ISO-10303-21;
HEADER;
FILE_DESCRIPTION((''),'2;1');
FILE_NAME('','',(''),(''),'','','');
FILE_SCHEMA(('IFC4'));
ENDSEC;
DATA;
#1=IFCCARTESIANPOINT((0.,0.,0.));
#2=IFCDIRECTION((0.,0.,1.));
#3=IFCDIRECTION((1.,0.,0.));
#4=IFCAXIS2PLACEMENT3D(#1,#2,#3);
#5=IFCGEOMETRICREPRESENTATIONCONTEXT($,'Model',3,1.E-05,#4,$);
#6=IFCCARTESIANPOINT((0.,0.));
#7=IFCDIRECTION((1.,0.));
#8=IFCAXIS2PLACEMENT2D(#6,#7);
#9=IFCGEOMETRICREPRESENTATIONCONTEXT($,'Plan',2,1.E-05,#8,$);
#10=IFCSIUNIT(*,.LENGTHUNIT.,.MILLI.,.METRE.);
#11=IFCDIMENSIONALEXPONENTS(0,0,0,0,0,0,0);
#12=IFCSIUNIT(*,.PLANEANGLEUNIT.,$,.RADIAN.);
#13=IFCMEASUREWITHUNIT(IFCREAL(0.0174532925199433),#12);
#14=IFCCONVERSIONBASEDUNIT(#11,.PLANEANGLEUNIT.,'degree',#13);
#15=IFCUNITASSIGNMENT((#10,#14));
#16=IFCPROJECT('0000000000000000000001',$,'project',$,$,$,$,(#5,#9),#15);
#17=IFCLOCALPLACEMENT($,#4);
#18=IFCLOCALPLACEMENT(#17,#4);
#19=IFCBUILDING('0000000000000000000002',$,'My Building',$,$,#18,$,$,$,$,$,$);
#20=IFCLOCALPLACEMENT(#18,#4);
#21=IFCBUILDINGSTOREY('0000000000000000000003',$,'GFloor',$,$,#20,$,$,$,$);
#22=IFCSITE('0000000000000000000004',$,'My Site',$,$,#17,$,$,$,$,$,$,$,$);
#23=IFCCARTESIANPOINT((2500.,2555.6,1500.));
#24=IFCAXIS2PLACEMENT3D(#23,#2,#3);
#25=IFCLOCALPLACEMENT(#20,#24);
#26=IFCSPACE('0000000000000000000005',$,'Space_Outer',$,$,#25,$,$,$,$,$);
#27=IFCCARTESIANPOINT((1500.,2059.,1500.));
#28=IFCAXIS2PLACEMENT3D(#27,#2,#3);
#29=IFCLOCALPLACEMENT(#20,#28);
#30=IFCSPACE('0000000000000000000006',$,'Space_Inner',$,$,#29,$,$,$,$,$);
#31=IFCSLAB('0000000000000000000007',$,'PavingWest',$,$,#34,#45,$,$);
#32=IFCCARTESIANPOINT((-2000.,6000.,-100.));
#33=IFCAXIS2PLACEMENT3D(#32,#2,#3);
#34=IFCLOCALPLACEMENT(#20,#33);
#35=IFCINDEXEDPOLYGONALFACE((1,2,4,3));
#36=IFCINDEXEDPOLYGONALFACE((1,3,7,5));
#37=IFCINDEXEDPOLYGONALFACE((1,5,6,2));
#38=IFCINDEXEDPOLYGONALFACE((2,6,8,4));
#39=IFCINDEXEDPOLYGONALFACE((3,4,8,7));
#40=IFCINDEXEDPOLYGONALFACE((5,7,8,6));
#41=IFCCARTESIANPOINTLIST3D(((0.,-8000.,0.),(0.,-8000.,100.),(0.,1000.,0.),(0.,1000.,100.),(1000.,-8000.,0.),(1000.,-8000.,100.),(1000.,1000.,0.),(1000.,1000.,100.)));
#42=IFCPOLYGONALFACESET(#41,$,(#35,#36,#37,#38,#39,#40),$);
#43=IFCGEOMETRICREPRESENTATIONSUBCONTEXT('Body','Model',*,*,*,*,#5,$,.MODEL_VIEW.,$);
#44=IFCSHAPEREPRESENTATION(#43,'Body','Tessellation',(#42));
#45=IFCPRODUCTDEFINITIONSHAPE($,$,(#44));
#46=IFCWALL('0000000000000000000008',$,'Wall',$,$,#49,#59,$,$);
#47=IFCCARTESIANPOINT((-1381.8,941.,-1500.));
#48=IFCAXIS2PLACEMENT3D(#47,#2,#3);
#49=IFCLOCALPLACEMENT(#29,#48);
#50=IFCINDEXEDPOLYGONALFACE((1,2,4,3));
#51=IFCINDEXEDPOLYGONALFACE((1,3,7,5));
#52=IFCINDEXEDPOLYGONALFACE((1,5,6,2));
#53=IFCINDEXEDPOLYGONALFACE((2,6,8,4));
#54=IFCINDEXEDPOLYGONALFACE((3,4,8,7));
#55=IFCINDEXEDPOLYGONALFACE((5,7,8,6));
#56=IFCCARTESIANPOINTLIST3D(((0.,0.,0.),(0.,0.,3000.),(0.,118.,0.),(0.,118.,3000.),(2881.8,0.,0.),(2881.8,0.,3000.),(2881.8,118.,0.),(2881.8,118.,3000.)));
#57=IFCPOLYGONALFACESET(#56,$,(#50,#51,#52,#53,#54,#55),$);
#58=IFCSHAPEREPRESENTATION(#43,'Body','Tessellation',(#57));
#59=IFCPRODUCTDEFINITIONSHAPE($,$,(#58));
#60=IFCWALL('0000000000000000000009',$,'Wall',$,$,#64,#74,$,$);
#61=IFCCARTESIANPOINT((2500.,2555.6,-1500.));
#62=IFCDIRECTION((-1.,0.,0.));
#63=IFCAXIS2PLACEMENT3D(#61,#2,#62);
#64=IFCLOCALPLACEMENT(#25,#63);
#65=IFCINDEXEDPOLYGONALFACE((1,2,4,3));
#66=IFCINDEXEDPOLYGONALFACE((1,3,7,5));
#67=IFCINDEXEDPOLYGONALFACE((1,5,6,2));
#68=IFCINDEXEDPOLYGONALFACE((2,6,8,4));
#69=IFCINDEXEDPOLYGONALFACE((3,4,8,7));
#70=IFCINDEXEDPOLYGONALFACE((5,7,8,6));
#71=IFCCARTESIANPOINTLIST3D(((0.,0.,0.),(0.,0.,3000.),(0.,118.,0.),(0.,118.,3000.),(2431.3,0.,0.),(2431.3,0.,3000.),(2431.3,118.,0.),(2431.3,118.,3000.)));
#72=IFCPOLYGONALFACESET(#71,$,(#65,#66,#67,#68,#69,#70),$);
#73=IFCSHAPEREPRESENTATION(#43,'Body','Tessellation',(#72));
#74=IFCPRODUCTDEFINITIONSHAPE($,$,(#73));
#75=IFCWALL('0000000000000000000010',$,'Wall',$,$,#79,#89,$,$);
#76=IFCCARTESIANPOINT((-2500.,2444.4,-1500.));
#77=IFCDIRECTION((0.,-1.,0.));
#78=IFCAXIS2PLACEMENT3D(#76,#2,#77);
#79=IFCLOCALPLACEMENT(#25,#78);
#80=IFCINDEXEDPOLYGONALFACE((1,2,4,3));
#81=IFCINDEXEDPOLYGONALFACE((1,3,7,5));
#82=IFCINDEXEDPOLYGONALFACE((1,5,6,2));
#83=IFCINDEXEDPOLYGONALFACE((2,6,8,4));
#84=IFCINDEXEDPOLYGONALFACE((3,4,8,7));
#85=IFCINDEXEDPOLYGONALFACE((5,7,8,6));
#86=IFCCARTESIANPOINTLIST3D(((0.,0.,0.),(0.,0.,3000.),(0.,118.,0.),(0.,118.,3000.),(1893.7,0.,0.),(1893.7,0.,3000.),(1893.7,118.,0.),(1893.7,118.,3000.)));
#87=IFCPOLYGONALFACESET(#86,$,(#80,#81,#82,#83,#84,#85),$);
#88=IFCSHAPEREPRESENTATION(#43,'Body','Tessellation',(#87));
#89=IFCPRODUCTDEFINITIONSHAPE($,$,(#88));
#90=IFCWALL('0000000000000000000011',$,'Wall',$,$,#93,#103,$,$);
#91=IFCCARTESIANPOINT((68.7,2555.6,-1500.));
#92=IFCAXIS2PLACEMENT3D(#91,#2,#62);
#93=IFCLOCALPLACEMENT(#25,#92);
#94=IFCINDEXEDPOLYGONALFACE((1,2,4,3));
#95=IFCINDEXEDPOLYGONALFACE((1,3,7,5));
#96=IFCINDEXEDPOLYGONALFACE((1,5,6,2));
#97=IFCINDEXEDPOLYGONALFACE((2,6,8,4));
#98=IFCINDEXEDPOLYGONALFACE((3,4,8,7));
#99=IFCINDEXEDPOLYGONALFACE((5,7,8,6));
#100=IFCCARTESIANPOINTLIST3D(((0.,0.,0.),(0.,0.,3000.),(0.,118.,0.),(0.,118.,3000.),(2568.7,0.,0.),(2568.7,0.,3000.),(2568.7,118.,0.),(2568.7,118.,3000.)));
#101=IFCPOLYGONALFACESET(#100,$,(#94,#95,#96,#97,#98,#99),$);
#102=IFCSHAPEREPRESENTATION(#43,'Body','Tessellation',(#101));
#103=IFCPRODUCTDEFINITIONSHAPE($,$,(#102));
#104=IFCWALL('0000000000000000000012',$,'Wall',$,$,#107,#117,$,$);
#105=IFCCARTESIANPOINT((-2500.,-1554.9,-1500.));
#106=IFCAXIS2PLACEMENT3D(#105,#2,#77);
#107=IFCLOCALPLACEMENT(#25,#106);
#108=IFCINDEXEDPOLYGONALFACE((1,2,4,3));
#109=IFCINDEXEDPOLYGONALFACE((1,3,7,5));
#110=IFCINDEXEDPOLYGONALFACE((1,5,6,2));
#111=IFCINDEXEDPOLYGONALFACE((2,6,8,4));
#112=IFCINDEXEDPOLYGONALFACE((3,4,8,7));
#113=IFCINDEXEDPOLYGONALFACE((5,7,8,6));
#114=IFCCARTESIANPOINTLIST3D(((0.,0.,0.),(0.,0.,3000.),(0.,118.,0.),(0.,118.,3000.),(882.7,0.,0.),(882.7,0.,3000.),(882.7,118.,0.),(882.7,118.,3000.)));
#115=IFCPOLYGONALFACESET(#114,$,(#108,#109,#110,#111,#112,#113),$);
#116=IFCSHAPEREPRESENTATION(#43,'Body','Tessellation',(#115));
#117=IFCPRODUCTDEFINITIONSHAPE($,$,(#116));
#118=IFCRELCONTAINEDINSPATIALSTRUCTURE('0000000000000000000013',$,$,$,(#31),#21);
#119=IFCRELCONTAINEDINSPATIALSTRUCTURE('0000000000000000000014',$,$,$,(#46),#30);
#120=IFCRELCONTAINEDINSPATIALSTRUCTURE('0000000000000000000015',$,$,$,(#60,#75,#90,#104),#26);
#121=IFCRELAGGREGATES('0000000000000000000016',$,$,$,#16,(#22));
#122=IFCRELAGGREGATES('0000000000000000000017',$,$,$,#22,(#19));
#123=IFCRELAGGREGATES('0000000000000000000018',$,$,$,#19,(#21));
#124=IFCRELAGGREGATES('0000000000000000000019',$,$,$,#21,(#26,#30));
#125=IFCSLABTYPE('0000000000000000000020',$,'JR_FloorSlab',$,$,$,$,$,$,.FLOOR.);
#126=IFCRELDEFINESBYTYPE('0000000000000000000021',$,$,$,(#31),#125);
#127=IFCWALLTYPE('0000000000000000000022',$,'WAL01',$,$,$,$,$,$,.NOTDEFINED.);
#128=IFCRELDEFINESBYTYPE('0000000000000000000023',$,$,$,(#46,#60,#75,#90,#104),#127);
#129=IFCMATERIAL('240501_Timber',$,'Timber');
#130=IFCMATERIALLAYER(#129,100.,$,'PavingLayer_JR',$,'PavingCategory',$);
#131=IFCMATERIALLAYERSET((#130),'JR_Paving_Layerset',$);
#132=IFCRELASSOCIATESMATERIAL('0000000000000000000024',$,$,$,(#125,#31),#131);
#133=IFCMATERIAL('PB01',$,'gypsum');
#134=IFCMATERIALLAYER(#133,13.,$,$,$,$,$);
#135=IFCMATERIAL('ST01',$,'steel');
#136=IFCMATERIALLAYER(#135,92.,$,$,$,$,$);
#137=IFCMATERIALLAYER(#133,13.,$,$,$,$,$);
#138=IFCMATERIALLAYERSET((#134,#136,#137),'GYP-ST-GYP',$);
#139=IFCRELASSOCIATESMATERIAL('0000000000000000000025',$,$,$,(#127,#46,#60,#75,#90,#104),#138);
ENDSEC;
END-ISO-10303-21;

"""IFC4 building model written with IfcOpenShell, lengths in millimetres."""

from ifc_helpers import new_model, entity, si_unit, converted_unit, frame, origin_with_axes, origin_2d_with_axis, place, context, subcontext, project, spatial, line, indexed_curve, outline, extrude, material, layer, layer_set, layer_usage, type_object, element, save


model = new_model("IFC4")

# Units and contexts
model_context = context("Model", 3, precision=1e-05, world=origin_with_axes())
plan_context = context("Plan", 2, precision=1e-05, world=origin_2d_with_axis())
body_context_1 = subcontext(model_context, "Body", "Model", "MODEL_VIEW")
ifc_project = project(units=[si_unit("LENGTHUNIT", "METRE", prefix="MILLI"), converted_unit("PLANEANGLEUNIT", "degree", entity("IfcReal", 0.0174532925199433), si_unit("PLANEANGLEUNIT", "RADIAN"), dimensions=[0, 0, 0, 0, 0, 0, 0])], contexts=[model_context, plan_context])

# Site, building, storey
site_placement = place(None, origin_with_axes())
site = spatial("IfcSite", under=ifc_project, at=site_placement, Name="My Site")
building_placement = place(site_placement, origin_with_axes())
building = spatial("IfcBuilding", under=site, at=building_placement, Name="My Building")
storey_placement = place(building_placement, origin_with_axes())
storey = spatial("IfcBuildingStorey", under=building, at=storey_placement, Name="GFloor")

# Slab
ifc_material_1 = material(Name="240501_Timber", Category="Timber")
ifc_layer_1 = layer(ifc_material_1, 100.0, Name="PavingLayer_JR", Category="PavingCategory")
ifc_layer_set_1 = layer_set([ifc_layer_1], Name="JR_Paving_Layerset")
slab_type = type_object("IfcSlabType", Name="JR_FloorSlab", PredefinedType="FLOOR", material=ifc_layer_set_1)
ifc_layer_usage_1 = layer_usage(ifc_layer_set_1, "AXIS3", "POSITIVE", 0.0)
slab_1_placement = place(storey_placement, frame((-2000.0, 6000.0, -100.0), z_axis=(0.0, 0.0, 1.0), x_axis=(1.0, 0.0, 0.0)))
element("IfcSlab", 1, at=slab_1_placement, inside=storey, type_object=slab_type, material=ifc_layer_usage_1, Name="PavingWest", context=body_context_1, shape_type="SweptSolid", body=[
    extrude(outline(indexed_curve([(0.0, -8000.0), (1000.0, -8000.0), (1000.0, 1000.0), (0.0, 1000.0)], segments=[line(4, 1), line(1, 2), line(2, 3), line(3, 4)], self_intersect=False)), None, (0.0, 0.0, 1.0), 100.0),
])

# Shared definitions
space_1_placement = place(storey_placement, frame((2500.0, 2555.6, 1500.0), z_axis=(0.0, 0.0, 1.0), x_axis=(1.0, 0.0, 0.0)))
space_1 = spatial("IfcSpace", under=storey, at=space_1_placement, Name="Space_Outer")

# Shared definitions
ifc_material_2 = material(Name="PB01", Category="gypsum")
ifc_layer_2 = layer(ifc_material_2, 13.0)
ifc_material_3 = material(Name="ST01", Category="steel")
ifc_layer_3 = layer(ifc_material_3, 92.0)
ifc_layer_4 = layer(ifc_material_2, 13.0)
ifc_layer_set_2 = layer_set([ifc_layer_2, ifc_layer_3, ifc_layer_4], Name="GYP-ST-GYP")
wall_type_1 = type_object("IfcWallType", Name="WAL01", PredefinedType="NOTDEFINED", material=ifc_layer_set_2)

# Shared definitions
space_2_placement = place(storey_placement, frame((1500.0, 2059.0, 1500.0), z_axis=(0.0, 0.0, 1.0), x_axis=(1.0, 0.0, 0.0)))
space_2 = spatial("IfcSpace", under=storey, at=space_2_placement, Name="Space_Inner")

# Walls
ifc_layer_usage_2 = layer_usage(ifc_layer_set_2, "AXIS2", "POSITIVE", 0.0)
wall_1_placement = place(space_2_placement, frame((-1381.8, 941.0, -1500.0), z_axis=(0.0, 0.0, 1.0), x_axis=(1.0, 0.0, 0.0)))
element("IfcWall", 2, at=wall_1_placement, inside=space_2, type_object=wall_type_1, material=ifc_layer_usage_2, Name="Wall", context=body_context_1, shape_type="SweptSolid", body=[
    extrude(outline(indexed_curve([(0.0, 0.0), (0.0, 118.0), (2881.8, 118.0), (2881.8, 0.0), (0.0, 0.0)], self_intersect=False)), origin_with_axes(), (0.0, 0.0, 1.0), 3000.0),
])
ifc_layer_usage_3 = layer_usage(ifc_layer_set_2, "AXIS2", "POSITIVE", 0.0)
wall_2_placement = place(space_1_placement, frame((2500.0, 2555.6, -1500.0), z_axis=(0.0, 0.0, 1.0), x_axis=(-1.0, 0.0, 0.0)))
element("IfcWall", 3, at=wall_2_placement, inside=space_1, type_object=wall_type_1, material=ifc_layer_usage_3, Name="Wall", context=body_context_1, shape_type="SweptSolid", body=[
    extrude(outline(indexed_curve([(0.0, 0.0), (0.0, 118.0), (2431.3, 118.0), (2431.3, 0.0), (0.0, 0.0)], self_intersect=False)), origin_with_axes(), (0.0, 0.0, 1.0), 3000.0),
])
ifc_layer_usage_4 = layer_usage(ifc_layer_set_2, "AXIS2", "POSITIVE", 0.0)
wall_3_placement = place(space_1_placement, frame((-2500.0, 2444.4, -1500.0), z_axis=(0.0, 0.0, 1.0), x_axis=(0.0, -1.0, 0.0)))
element("IfcWall", 4, at=wall_3_placement, inside=space_1, type_object=wall_type_1, material=ifc_layer_usage_4, Name="Wall", context=body_context_1, shape_type="SweptSolid", body=[
    extrude(outline(indexed_curve([(0.0, 0.0), (0.0, 118.0), (1893.7, 118.0), (1893.7, 0.0), (0.0, 0.0)], self_intersect=False)), origin_with_axes(), (0.0, 0.0, 1.0), 3000.0),
])
ifc_layer_usage_5 = layer_usage(ifc_layer_set_2, "AXIS2", "POSITIVE", 0.0)
wall_4_placement = place(space_1_placement, frame((68.7, 2555.6, -1500.0), z_axis=(0.0, 0.0, 1.0), x_axis=(-1.0, 0.0, 0.0)))
element("IfcWall", 5, at=wall_4_placement, inside=space_1, type_object=wall_type_1, material=ifc_layer_usage_5, Name="Wall", context=body_context_1, shape_type="SweptSolid", body=[
    extrude(outline(indexed_curve([(0.0, 0.0), (0.0, 118.0), (2568.7, 118.0), (2568.7, 0.0), (0.0, 0.0)], self_intersect=False)), origin_with_axes(), (0.0, 0.0, 1.0), 3000.0),
])
ifc_layer_usage_6 = layer_usage(ifc_layer_set_2, "AXIS2", "POSITIVE", 0.0)
wall_5_placement = place(space_1_placement, frame((-2500.0, -1554.9, -1500.0), z_axis=(0.0, 0.0, 1.0), x_axis=(0.0, -1.0, 0.0)))
element("IfcWall", 6, at=wall_5_placement, inside=space_1, type_object=wall_type_1, material=ifc_layer_usage_6, Name="Wall", context=body_context_1, shape_type="SweptSolid", body=[
    extrude(outline(indexed_curve([(0.0, 0.0), (0.0, 118.0), (882.7, 118.0), (882.7, 0.0), (0.0, 0.0)], self_intersect=False)), origin_with_axes(), (0.0, 0.0, 1.0), 3000.0),
])

save(model, "model.ifc")
